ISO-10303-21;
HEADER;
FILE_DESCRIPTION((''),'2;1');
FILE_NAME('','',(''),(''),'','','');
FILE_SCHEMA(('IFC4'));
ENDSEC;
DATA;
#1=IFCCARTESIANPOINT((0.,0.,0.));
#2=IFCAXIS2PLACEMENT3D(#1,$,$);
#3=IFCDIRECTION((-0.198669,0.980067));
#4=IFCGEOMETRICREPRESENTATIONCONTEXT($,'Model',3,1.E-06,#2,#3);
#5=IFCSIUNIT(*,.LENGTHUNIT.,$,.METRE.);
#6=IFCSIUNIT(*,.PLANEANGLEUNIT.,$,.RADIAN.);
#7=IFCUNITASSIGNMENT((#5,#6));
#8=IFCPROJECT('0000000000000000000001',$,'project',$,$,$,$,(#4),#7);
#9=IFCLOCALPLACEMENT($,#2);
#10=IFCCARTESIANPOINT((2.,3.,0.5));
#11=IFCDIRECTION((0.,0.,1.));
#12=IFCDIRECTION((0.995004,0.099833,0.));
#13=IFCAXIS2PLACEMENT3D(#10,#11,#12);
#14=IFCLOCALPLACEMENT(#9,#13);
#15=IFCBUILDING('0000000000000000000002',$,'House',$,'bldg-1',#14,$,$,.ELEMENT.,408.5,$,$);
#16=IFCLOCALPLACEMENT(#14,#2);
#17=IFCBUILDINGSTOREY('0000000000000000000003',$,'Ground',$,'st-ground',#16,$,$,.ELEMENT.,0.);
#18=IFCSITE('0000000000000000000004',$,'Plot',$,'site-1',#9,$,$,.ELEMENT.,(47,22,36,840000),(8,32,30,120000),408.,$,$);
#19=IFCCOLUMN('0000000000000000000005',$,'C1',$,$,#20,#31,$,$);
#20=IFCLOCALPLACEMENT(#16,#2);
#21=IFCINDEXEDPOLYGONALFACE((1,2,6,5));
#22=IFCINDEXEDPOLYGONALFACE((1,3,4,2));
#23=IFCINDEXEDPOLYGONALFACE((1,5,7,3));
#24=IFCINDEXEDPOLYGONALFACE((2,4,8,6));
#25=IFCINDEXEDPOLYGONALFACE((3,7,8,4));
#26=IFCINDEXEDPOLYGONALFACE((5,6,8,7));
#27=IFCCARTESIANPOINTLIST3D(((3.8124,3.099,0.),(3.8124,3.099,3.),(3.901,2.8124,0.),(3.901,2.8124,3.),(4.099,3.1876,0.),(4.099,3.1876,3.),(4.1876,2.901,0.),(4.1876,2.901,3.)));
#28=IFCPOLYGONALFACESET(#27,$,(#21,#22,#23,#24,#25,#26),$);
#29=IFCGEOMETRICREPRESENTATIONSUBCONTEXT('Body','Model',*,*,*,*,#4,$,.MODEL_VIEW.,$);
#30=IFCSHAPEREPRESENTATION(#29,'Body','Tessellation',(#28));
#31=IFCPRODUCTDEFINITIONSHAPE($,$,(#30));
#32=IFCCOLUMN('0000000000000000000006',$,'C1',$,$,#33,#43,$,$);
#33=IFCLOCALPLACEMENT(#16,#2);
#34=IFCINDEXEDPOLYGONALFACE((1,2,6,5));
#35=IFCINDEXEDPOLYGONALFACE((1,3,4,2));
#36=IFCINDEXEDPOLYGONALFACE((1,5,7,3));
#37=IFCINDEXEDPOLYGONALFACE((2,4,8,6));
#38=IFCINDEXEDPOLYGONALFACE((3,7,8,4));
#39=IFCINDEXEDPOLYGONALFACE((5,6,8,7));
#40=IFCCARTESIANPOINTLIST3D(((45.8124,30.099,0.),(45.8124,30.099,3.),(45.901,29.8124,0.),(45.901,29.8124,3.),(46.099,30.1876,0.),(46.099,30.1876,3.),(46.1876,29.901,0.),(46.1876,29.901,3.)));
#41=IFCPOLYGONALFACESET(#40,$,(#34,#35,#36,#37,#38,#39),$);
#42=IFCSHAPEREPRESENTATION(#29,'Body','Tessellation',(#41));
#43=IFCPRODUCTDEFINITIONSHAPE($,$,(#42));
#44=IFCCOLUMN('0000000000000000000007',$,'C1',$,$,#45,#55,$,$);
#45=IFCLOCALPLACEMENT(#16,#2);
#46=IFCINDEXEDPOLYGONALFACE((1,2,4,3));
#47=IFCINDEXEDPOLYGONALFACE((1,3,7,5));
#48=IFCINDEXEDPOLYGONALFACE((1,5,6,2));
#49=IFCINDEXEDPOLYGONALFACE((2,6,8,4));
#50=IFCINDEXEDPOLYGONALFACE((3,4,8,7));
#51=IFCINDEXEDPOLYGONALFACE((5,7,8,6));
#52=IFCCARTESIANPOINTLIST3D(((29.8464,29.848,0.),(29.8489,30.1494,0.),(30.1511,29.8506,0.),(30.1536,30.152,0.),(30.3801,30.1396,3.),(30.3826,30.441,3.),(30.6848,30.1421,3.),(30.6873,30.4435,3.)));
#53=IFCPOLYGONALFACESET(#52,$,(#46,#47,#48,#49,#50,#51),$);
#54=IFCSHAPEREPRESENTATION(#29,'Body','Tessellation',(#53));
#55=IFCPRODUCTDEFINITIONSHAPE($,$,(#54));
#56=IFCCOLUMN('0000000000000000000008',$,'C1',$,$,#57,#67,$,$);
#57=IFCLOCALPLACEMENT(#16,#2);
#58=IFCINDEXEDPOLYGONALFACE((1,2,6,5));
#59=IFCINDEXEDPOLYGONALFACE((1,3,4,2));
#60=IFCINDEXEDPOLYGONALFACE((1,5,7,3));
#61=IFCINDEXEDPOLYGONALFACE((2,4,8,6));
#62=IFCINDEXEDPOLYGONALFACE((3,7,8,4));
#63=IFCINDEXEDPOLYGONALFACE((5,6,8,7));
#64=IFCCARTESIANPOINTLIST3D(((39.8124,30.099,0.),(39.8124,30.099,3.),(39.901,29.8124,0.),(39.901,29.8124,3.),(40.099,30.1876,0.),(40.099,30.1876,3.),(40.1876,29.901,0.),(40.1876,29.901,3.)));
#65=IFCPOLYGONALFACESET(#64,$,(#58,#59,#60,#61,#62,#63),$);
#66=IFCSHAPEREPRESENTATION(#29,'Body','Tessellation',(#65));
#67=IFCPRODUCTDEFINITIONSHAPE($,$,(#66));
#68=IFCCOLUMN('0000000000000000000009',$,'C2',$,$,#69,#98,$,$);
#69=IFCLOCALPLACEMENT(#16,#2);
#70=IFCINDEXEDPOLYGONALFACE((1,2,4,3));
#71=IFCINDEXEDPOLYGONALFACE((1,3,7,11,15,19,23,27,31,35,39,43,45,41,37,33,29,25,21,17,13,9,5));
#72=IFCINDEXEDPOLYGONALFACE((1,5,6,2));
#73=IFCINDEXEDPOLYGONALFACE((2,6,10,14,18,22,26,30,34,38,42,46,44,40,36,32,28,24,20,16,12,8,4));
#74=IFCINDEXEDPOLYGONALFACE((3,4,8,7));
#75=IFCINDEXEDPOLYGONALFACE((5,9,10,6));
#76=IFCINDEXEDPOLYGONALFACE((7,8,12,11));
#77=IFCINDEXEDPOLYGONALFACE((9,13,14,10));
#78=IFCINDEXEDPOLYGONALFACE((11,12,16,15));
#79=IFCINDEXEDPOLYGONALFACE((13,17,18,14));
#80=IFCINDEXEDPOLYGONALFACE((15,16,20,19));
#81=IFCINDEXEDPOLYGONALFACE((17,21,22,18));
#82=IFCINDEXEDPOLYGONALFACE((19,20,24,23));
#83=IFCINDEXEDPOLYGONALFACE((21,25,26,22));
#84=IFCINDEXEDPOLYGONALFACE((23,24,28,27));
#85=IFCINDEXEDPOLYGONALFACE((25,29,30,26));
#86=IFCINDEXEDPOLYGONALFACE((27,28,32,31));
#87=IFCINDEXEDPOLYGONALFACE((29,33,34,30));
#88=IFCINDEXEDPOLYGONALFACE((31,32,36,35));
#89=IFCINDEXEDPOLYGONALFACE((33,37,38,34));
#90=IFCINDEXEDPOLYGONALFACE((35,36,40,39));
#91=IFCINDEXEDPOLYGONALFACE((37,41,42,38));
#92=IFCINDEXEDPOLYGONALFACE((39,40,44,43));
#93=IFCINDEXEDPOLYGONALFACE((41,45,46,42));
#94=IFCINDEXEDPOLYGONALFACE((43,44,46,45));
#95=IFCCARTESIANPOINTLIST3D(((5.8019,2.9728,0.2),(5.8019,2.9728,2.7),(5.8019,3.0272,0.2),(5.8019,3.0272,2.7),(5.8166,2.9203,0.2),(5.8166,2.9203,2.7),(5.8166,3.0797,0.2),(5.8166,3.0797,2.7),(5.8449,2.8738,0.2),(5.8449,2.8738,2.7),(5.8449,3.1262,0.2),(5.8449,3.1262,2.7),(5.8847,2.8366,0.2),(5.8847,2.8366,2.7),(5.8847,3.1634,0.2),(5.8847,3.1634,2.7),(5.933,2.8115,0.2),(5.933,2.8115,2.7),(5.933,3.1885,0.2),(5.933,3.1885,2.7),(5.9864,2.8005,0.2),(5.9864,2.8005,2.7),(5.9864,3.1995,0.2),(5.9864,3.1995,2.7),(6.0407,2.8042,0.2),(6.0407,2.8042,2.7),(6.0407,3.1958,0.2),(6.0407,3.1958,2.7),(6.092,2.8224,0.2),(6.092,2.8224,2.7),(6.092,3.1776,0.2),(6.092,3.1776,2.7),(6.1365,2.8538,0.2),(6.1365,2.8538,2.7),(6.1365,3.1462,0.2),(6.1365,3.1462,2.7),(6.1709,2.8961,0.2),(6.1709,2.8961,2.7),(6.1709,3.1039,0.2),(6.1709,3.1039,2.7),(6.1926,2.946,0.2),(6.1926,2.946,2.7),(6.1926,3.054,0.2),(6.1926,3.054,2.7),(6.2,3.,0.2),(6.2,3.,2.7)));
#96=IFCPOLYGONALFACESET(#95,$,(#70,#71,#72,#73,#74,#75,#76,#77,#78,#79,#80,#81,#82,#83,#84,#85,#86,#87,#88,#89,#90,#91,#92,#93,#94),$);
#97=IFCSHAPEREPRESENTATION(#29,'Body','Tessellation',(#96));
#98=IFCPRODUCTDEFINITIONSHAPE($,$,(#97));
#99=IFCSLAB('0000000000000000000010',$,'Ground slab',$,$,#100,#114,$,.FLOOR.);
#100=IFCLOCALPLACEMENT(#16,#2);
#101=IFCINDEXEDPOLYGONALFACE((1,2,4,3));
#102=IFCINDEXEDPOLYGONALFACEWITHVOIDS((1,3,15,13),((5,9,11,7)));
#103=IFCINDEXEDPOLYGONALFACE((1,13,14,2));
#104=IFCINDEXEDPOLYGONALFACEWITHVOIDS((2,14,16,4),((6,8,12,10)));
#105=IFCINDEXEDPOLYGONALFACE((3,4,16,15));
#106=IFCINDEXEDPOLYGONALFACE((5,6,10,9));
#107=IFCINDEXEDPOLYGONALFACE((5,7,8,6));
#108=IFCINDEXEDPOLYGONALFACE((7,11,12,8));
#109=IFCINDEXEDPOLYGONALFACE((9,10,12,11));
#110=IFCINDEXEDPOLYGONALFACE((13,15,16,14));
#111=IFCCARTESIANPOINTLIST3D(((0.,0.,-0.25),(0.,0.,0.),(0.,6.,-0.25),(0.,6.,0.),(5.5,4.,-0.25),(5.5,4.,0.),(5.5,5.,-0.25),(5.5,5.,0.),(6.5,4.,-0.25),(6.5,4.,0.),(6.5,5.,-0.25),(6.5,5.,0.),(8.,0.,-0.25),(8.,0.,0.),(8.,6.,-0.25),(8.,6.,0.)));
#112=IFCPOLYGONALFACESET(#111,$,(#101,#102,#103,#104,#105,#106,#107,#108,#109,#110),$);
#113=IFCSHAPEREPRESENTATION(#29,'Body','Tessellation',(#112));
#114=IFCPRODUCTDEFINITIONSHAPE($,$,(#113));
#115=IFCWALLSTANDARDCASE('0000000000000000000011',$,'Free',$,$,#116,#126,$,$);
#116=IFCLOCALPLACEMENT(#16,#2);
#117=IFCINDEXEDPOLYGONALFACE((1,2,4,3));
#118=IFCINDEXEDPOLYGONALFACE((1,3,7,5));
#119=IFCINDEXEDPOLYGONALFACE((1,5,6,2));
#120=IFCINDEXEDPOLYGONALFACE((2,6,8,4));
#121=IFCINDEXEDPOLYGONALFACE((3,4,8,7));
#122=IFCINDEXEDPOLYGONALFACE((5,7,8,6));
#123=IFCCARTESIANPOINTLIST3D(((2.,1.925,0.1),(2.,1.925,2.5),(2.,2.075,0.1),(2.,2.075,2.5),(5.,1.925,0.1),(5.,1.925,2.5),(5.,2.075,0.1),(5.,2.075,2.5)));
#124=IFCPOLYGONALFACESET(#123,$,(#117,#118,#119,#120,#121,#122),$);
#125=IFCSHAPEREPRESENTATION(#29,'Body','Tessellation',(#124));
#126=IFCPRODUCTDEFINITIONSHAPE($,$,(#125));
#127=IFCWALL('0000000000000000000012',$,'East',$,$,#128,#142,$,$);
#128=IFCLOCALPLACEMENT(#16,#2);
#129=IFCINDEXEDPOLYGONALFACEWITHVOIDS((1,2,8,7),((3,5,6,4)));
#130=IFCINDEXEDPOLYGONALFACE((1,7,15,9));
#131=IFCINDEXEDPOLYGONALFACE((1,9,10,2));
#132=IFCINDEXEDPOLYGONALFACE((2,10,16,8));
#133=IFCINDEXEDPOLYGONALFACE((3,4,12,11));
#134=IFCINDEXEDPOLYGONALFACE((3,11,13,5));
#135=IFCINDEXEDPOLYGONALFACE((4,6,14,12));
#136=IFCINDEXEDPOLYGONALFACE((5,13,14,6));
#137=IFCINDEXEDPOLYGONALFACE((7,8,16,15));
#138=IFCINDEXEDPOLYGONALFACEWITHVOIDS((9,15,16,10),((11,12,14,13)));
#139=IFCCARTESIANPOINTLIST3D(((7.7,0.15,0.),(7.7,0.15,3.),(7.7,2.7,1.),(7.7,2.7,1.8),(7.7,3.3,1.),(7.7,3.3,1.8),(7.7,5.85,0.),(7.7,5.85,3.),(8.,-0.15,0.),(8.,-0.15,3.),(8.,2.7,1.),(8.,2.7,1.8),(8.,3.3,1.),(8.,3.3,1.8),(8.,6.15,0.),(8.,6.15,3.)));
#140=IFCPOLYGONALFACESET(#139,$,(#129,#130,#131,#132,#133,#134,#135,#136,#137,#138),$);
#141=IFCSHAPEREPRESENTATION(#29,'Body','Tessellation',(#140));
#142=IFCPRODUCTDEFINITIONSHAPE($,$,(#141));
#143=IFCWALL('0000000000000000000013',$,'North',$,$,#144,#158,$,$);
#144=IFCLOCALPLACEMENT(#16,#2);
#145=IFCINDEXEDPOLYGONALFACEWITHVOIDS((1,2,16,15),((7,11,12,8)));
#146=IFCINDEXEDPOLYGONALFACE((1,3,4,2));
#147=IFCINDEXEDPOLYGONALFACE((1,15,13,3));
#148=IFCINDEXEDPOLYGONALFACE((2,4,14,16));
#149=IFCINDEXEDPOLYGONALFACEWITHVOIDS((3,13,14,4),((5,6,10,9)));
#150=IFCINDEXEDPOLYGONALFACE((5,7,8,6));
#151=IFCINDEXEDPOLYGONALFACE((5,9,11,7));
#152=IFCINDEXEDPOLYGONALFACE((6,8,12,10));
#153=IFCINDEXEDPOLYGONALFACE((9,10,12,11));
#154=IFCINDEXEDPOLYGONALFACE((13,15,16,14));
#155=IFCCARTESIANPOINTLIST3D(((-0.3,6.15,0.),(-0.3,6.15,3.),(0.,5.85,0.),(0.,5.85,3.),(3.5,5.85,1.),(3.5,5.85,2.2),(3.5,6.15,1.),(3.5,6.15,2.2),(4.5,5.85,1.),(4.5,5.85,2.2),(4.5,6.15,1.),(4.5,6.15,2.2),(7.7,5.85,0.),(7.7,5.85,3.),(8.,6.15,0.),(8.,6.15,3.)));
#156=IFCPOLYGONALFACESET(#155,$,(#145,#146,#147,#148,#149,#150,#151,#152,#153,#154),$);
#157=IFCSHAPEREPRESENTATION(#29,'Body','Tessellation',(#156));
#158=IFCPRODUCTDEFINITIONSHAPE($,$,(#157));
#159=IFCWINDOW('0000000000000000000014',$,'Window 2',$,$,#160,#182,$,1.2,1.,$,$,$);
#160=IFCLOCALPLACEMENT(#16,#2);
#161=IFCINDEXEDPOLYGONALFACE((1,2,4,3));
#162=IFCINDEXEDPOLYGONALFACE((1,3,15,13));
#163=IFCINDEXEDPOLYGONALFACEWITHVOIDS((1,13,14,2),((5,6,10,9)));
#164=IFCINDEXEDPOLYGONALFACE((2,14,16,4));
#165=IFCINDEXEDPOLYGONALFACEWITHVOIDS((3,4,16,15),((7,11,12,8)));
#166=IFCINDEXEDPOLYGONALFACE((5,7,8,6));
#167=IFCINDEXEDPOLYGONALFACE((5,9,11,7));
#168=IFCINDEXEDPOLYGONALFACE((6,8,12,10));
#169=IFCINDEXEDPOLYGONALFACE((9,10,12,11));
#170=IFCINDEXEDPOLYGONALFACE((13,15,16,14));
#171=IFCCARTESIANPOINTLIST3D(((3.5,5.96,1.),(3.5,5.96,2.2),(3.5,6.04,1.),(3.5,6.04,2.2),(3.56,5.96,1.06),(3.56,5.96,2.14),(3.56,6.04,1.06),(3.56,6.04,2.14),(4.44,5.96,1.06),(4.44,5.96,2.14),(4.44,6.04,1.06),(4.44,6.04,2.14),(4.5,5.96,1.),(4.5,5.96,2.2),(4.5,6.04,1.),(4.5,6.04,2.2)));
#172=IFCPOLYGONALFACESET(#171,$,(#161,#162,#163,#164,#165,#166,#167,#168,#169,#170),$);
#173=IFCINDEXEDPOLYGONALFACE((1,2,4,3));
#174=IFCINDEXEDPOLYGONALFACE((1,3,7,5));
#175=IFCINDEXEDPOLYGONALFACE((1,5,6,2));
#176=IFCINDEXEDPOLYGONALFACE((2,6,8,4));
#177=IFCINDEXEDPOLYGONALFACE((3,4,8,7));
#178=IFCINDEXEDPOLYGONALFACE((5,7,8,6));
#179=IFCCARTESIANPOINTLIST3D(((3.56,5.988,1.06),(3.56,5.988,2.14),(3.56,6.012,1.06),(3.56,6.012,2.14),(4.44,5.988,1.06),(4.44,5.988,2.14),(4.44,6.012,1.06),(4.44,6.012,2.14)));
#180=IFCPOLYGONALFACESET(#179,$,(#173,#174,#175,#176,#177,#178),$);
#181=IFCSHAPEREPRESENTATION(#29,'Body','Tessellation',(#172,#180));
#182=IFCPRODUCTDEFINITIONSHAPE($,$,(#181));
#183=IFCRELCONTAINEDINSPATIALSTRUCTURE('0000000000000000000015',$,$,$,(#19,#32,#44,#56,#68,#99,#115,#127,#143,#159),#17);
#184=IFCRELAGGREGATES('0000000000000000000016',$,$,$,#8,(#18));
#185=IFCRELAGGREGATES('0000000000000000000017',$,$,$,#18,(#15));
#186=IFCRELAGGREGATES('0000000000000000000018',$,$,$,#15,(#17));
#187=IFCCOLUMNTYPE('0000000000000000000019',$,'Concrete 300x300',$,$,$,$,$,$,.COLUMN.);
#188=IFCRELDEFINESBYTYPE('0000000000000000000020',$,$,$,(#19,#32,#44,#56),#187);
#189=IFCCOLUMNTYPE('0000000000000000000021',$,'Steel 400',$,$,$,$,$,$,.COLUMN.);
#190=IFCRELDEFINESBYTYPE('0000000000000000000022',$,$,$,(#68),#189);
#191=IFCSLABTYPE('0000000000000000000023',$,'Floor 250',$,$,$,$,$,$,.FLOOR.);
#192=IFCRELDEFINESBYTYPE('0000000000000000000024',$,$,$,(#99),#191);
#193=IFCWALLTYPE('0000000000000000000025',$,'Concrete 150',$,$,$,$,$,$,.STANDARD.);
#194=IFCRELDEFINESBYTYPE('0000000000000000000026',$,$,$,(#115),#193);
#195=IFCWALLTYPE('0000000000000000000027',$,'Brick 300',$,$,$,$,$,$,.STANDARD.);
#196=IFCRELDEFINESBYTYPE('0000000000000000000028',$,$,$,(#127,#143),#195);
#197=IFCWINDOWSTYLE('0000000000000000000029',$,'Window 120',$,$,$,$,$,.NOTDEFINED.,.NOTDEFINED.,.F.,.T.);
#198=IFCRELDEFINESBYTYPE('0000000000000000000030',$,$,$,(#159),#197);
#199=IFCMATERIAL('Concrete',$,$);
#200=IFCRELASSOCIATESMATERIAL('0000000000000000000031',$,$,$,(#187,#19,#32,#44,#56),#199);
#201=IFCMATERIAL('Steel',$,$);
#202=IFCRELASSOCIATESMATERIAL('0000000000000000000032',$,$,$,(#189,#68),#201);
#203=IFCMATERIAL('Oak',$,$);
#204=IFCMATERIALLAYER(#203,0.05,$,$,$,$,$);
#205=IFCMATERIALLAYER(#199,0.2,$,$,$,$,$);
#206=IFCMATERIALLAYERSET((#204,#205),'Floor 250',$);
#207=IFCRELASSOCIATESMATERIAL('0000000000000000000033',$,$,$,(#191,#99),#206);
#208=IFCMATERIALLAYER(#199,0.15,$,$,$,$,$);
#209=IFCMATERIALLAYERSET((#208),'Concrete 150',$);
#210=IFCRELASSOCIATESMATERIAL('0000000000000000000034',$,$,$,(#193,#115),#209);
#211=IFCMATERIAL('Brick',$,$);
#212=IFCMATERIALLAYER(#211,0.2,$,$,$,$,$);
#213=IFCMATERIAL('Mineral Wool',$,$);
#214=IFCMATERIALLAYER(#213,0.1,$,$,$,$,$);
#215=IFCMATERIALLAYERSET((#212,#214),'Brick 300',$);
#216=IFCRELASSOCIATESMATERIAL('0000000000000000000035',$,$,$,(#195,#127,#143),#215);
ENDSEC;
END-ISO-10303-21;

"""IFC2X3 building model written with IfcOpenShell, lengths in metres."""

from ifc_helpers import new_model, si_unit, direction, frame, frame_2d, origin, origin_2d, place, context, subcontext, project, spatial, polyline, rectangle, circle, outline, extrude, material, layer, layer_set, layer_usage, type_object, element, fill, save


model = new_model("IFC2X3")

# Units and contexts
model_context = context("Model", 3, precision=1e-06, world=origin(), true_north=direction((-0.198669, 0.980067)))
body_context = subcontext(model_context, "Body", "Model", "MODEL_VIEW")
ifc_project = project(units=[si_unit("LENGTHUNIT", "METRE"), si_unit("PLANEANGLEUNIT", "RADIAN")], contexts=[model_context])

# Site, building, storey
site_placement = place(None, origin())
site = spatial("IfcSite", under=ifc_project, at=site_placement, Name="Plot", ObjectType="site-1", CompositionType="ELEMENT", RefLatitude=(47, 22, 36, 840000), RefLongitude=(8, 32, 30, 120000), RefElevation=408.0)
building_placement = place(site_placement, frame((2.0, 3.0, 0.5), z_axis=(0.0, 0.0, 1.0), x_axis=(0.995004, 0.099833, 0.0)))
building = spatial("IfcBuilding", under=site, at=building_placement, Name="House", ObjectType="bldg-1", CompositionType="ELEMENT", ElevationOfRefHeight=408.5)
storey_placement = place(building_placement, origin())
storey = spatial("IfcBuildingStorey", under=building, at=storey_placement, Name="Ground", ObjectType="st-ground", CompositionType="ELEMENT", Elevation=0.0)

# Columns
ifc_material_1 = material(Name="Concrete")
column_type_1 = type_object("IfcColumnType", Name="Concrete 300x300", PredefinedType="COLUMN", material=ifc_material_1)
for number, where, z_axis, x_axis, name in (
    (1, (4.0, 3.0, 0.0), (0.0, 0.0, 1.0), (0.955336, 0.29552, 0.0), "C1"),
    (2, (46.0, 30.0, 0.0), (0.0, 0.0, 1.0), (0.955336, 0.29552, 0.0), "C1"),
):
    element("IfcColumn", number, at=place(storey_placement, frame(where, z_axis=z_axis, x_axis=x_axis)), inside=storey, type_object=column_type_1, material=ifc_material_1, Name=name, context=body_context, shape_type="SweptSolid", body=[
        extrude(rectangle(XDim=0.3, YDim=0.3, at=origin_2d()), origin(), (0.0, 0.0, 1.0), 3.0),
    ])
column_1_placement = place(storey_placement, frame((30.0, 30.0, 0.0)))
element("IfcColumn", 3, at=column_1_placement, inside=storey, type_object=column_type_1, material=ifc_material_1, Name="C1", context=body_context, shape_type="SweptSolid", body=[
    extrude(outline(polyline([(-0.1536, -0.152), (0.1511, -0.1494), (0.1536, 0.152), (-0.1511, 0.1494), (-0.1536, -0.152)])), origin(), (0.174349, 0.095247, 0.980067), 3.061),
])
column_2_placement = place(storey_placement, frame((40.0, 30.0, 0.0), z_axis=(0.0, 0.0, 1.0), x_axis=(0.955336, 0.29552, 0.0)))
element("IfcColumn", 4, at=column_2_placement, inside=storey, type_object=column_type_1, material=ifc_material_1, Name="C1", context=body_context, shape_type="SweptSolid", body=[
    extrude(rectangle(XDim=0.3, YDim=0.3, at=origin_2d()), origin(), (0.0, 0.0, 1.0), 3.0),
])
ifc_material_2 = material(Name="Steel")
column_type_2 = type_object("IfcColumnType", Name="Steel 400", PredefinedType="COLUMN", material=ifc_material_2)
column_3_placement = place(storey_placement, frame((6.0, 3.0, 0.2)))
element("IfcColumn", 5, at=column_3_placement, inside=storey, type_object=column_type_2, material=ifc_material_2, Name="C2", context=body_context, shape_type="SweptSolid", body=[
    extrude(circle(Radius=0.2, at=origin_2d()), origin(), (0.0, 0.0, 1.0), 2.5),
])

# Slab
ifc_material_3 = material(Name="Oak")
ifc_layer_1 = layer(ifc_material_3, 0.05)
ifc_layer_2 = layer(ifc_material_1, 0.2)
ifc_layer_set_1 = layer_set([ifc_layer_1, ifc_layer_2], Name="Floor 250")
ifc_layer_usage_1 = layer_usage(ifc_layer_set_1, "AXIS3", "NEGATIVE", 0.25)
slab_type = type_object("IfcSlabType", Name="Floor 250", PredefinedType="FLOOR", material=ifc_layer_set_1)
slab_placement = place(storey_placement, frame((0.0, 0.0, -0.25)))
element("IfcSlab", 6, at=slab_placement, inside=storey, type_object=slab_type, material=ifc_layer_usage_1, Name="Ground slab", PredefinedType="FLOOR", context=body_context, shape_type="SweptSolid", body=[
    extrude(outline(polyline([(0.0, 0.0), (8.0, 0.0), (8.0, 6.0), (0.0, 6.0), (0.0, 0.0)]), holes=[polyline([(5.5, 4.0), (5.5, 5.0), (6.5, 5.0), (6.5, 4.0), (5.5, 4.0)])]), origin(), (0.0, 0.0, 1.0), 0.25),
])

# Shared definitions
ifc_layer_3 = layer(ifc_material_1, 0.15)
ifc_layer_set_2 = layer_set([ifc_layer_3], Name="Concrete 150")
wall_type_1 = type_object("IfcWallType", Name="Concrete 150", PredefinedType="STANDARD", material=ifc_layer_set_2)
window_style = type_object("IfcWindowStyle", Name="Window 120", ConstructionType="NOTDEFINED", OperationType="NOTDEFINED", ParameterTakesPrecedence=False, Sizeable=True)

# Wall
ifc_layer_usage_2 = layer_usage(ifc_layer_set_2, "AXIS2", "NEGATIVE", 0.075)
wall_1_placement = place(storey_placement, frame((2.0, 2.0, 0.1), z_axis=(0.0, 0.0, 1.0), x_axis=(1.0, 0.0, 0.0)))
element("IfcWallStandardCase", 7, at=wall_1_placement, inside=storey, type_object=wall_type_1, material=ifc_layer_usage_2, Name="Free", context=body_context, shape_type="SweptSolid", body=[
    extrude(rectangle(XDim=3.0, YDim=0.15, at=frame_2d((1.5, 0.0))), origin(), (0.0, 0.0, 1.0), 2.4),
])

# Wall, opening
ifc_material_4 = material(Name="Brick")
ifc_layer_4 = layer(ifc_material_4, 0.2)
ifc_material_5 = material(Name="Mineral Wool")
ifc_layer_5 = layer(ifc_material_5, 0.1)
ifc_layer_set_3 = layer_set([ifc_layer_4, ifc_layer_5], Name="Brick 300")
ifc_layer_usage_3 = layer_usage(ifc_layer_set_3, "AXIS2", "NEGATIVE", 0.3)
wall_type_2 = type_object("IfcWallType", Name="Brick 300", PredefinedType="STANDARD", material=ifc_layer_set_3)
wall_2_placement = place(storey_placement, origin())
wall_2 = element("IfcWall", 8, at=wall_2_placement, inside=storey, type_object=wall_type_2, material=ifc_layer_usage_3, Name="East", context=body_context, shape_type="SweptSolid", body=[
    extrude(outline(polyline([(8.0, -0.15), (8.0, 6.15), (7.7, 5.85), (7.7, 0.15), (8.0, -0.15)])), origin(), (0.0, 0.0, 1.0), 3.0),
])
opening_1_placement = place(wall_2_placement, frame((7.85, 3.0, 1.0), z_axis=(0.0, 0.0, 1.0), x_axis=(0.0, 1.0, 0.0)))
element("IfcOpeningElement", 9, at=opening_1_placement, cuts=wall_2, context=body_context, shape_type="SweptSolid", body=[
    extrude(rectangle(XDim=0.6, YDim=0.3, at=origin_2d()), origin(), (0.0, 0.0, 1.0), 0.8),
])

# Wall, opening, window
ifc_layer_usage_4 = layer_usage(ifc_layer_set_3, "AXIS2", "NEGATIVE", 0.15)
wall_3_placement = place(storey_placement, origin())
wall_3 = element("IfcWall", 10, at=wall_3_placement, inside=storey, type_object=wall_type_2, material=ifc_layer_usage_4, Name="North", context=body_context, shape_type="SweptSolid", body=[
    extrude(outline(polyline([(8.0, 6.15), (-0.3, 6.15), (0.0, 5.85), (7.7, 5.85), (8.0, 6.15)])), origin(), (0.0, 0.0, 1.0), 3.0),
])
opening_2_placement = place(wall_3_placement, frame((4.0, 6.0, 1.0), z_axis=(0.0, 0.0, 1.0), x_axis=(-1.0, 0.0, 0.0)))
opening_2 = element("IfcOpeningElement", 11, at=opening_2_placement, cuts=wall_3, context=body_context, shape_type="SweptSolid", body=[
    extrude(rectangle(XDim=1.0, YDim=0.3, at=origin_2d()), origin(), (0.0, 0.0, 1.0), 1.2),
])
window_1_placement = place(opening_2_placement, frame((0.0, 0.0, 0.0), z_axis=(0.0, 1.0, 0.0), x_axis=(-1.0, 0.0, 0.0)))
window_1 = element("IfcWindow", 12, at=window_1_placement, inside=storey, type_object=window_style, Name="Window 2", OverallHeight=1.2, OverallWidth=1.0, context=body_context, shape_type="SweptSolid", body=[
    extrude(outline(polyline([(-0.5, 0.0), (0.5, 0.0), (0.5, 1.2), (-0.5, 1.2), (-0.5, 0.0)]), holes=[polyline([(-0.44, 0.06), (0.44, 0.06), (0.44, 1.14), (-0.44, 1.14), (-0.44, 0.06)])]), frame((0.0, 0.0, -0.04)), (0.0, 0.0, 1.0), 0.08),
    extrude(rectangle(XDim=0.88, YDim=1.08, at=frame_2d((0.0, 0.6))), frame((0.0, 0.0, -0.012)), (0.0, 0.0, 1.0), 0.024),
])
fill(opening_2, window_1)

save(model, "model.ifc")
